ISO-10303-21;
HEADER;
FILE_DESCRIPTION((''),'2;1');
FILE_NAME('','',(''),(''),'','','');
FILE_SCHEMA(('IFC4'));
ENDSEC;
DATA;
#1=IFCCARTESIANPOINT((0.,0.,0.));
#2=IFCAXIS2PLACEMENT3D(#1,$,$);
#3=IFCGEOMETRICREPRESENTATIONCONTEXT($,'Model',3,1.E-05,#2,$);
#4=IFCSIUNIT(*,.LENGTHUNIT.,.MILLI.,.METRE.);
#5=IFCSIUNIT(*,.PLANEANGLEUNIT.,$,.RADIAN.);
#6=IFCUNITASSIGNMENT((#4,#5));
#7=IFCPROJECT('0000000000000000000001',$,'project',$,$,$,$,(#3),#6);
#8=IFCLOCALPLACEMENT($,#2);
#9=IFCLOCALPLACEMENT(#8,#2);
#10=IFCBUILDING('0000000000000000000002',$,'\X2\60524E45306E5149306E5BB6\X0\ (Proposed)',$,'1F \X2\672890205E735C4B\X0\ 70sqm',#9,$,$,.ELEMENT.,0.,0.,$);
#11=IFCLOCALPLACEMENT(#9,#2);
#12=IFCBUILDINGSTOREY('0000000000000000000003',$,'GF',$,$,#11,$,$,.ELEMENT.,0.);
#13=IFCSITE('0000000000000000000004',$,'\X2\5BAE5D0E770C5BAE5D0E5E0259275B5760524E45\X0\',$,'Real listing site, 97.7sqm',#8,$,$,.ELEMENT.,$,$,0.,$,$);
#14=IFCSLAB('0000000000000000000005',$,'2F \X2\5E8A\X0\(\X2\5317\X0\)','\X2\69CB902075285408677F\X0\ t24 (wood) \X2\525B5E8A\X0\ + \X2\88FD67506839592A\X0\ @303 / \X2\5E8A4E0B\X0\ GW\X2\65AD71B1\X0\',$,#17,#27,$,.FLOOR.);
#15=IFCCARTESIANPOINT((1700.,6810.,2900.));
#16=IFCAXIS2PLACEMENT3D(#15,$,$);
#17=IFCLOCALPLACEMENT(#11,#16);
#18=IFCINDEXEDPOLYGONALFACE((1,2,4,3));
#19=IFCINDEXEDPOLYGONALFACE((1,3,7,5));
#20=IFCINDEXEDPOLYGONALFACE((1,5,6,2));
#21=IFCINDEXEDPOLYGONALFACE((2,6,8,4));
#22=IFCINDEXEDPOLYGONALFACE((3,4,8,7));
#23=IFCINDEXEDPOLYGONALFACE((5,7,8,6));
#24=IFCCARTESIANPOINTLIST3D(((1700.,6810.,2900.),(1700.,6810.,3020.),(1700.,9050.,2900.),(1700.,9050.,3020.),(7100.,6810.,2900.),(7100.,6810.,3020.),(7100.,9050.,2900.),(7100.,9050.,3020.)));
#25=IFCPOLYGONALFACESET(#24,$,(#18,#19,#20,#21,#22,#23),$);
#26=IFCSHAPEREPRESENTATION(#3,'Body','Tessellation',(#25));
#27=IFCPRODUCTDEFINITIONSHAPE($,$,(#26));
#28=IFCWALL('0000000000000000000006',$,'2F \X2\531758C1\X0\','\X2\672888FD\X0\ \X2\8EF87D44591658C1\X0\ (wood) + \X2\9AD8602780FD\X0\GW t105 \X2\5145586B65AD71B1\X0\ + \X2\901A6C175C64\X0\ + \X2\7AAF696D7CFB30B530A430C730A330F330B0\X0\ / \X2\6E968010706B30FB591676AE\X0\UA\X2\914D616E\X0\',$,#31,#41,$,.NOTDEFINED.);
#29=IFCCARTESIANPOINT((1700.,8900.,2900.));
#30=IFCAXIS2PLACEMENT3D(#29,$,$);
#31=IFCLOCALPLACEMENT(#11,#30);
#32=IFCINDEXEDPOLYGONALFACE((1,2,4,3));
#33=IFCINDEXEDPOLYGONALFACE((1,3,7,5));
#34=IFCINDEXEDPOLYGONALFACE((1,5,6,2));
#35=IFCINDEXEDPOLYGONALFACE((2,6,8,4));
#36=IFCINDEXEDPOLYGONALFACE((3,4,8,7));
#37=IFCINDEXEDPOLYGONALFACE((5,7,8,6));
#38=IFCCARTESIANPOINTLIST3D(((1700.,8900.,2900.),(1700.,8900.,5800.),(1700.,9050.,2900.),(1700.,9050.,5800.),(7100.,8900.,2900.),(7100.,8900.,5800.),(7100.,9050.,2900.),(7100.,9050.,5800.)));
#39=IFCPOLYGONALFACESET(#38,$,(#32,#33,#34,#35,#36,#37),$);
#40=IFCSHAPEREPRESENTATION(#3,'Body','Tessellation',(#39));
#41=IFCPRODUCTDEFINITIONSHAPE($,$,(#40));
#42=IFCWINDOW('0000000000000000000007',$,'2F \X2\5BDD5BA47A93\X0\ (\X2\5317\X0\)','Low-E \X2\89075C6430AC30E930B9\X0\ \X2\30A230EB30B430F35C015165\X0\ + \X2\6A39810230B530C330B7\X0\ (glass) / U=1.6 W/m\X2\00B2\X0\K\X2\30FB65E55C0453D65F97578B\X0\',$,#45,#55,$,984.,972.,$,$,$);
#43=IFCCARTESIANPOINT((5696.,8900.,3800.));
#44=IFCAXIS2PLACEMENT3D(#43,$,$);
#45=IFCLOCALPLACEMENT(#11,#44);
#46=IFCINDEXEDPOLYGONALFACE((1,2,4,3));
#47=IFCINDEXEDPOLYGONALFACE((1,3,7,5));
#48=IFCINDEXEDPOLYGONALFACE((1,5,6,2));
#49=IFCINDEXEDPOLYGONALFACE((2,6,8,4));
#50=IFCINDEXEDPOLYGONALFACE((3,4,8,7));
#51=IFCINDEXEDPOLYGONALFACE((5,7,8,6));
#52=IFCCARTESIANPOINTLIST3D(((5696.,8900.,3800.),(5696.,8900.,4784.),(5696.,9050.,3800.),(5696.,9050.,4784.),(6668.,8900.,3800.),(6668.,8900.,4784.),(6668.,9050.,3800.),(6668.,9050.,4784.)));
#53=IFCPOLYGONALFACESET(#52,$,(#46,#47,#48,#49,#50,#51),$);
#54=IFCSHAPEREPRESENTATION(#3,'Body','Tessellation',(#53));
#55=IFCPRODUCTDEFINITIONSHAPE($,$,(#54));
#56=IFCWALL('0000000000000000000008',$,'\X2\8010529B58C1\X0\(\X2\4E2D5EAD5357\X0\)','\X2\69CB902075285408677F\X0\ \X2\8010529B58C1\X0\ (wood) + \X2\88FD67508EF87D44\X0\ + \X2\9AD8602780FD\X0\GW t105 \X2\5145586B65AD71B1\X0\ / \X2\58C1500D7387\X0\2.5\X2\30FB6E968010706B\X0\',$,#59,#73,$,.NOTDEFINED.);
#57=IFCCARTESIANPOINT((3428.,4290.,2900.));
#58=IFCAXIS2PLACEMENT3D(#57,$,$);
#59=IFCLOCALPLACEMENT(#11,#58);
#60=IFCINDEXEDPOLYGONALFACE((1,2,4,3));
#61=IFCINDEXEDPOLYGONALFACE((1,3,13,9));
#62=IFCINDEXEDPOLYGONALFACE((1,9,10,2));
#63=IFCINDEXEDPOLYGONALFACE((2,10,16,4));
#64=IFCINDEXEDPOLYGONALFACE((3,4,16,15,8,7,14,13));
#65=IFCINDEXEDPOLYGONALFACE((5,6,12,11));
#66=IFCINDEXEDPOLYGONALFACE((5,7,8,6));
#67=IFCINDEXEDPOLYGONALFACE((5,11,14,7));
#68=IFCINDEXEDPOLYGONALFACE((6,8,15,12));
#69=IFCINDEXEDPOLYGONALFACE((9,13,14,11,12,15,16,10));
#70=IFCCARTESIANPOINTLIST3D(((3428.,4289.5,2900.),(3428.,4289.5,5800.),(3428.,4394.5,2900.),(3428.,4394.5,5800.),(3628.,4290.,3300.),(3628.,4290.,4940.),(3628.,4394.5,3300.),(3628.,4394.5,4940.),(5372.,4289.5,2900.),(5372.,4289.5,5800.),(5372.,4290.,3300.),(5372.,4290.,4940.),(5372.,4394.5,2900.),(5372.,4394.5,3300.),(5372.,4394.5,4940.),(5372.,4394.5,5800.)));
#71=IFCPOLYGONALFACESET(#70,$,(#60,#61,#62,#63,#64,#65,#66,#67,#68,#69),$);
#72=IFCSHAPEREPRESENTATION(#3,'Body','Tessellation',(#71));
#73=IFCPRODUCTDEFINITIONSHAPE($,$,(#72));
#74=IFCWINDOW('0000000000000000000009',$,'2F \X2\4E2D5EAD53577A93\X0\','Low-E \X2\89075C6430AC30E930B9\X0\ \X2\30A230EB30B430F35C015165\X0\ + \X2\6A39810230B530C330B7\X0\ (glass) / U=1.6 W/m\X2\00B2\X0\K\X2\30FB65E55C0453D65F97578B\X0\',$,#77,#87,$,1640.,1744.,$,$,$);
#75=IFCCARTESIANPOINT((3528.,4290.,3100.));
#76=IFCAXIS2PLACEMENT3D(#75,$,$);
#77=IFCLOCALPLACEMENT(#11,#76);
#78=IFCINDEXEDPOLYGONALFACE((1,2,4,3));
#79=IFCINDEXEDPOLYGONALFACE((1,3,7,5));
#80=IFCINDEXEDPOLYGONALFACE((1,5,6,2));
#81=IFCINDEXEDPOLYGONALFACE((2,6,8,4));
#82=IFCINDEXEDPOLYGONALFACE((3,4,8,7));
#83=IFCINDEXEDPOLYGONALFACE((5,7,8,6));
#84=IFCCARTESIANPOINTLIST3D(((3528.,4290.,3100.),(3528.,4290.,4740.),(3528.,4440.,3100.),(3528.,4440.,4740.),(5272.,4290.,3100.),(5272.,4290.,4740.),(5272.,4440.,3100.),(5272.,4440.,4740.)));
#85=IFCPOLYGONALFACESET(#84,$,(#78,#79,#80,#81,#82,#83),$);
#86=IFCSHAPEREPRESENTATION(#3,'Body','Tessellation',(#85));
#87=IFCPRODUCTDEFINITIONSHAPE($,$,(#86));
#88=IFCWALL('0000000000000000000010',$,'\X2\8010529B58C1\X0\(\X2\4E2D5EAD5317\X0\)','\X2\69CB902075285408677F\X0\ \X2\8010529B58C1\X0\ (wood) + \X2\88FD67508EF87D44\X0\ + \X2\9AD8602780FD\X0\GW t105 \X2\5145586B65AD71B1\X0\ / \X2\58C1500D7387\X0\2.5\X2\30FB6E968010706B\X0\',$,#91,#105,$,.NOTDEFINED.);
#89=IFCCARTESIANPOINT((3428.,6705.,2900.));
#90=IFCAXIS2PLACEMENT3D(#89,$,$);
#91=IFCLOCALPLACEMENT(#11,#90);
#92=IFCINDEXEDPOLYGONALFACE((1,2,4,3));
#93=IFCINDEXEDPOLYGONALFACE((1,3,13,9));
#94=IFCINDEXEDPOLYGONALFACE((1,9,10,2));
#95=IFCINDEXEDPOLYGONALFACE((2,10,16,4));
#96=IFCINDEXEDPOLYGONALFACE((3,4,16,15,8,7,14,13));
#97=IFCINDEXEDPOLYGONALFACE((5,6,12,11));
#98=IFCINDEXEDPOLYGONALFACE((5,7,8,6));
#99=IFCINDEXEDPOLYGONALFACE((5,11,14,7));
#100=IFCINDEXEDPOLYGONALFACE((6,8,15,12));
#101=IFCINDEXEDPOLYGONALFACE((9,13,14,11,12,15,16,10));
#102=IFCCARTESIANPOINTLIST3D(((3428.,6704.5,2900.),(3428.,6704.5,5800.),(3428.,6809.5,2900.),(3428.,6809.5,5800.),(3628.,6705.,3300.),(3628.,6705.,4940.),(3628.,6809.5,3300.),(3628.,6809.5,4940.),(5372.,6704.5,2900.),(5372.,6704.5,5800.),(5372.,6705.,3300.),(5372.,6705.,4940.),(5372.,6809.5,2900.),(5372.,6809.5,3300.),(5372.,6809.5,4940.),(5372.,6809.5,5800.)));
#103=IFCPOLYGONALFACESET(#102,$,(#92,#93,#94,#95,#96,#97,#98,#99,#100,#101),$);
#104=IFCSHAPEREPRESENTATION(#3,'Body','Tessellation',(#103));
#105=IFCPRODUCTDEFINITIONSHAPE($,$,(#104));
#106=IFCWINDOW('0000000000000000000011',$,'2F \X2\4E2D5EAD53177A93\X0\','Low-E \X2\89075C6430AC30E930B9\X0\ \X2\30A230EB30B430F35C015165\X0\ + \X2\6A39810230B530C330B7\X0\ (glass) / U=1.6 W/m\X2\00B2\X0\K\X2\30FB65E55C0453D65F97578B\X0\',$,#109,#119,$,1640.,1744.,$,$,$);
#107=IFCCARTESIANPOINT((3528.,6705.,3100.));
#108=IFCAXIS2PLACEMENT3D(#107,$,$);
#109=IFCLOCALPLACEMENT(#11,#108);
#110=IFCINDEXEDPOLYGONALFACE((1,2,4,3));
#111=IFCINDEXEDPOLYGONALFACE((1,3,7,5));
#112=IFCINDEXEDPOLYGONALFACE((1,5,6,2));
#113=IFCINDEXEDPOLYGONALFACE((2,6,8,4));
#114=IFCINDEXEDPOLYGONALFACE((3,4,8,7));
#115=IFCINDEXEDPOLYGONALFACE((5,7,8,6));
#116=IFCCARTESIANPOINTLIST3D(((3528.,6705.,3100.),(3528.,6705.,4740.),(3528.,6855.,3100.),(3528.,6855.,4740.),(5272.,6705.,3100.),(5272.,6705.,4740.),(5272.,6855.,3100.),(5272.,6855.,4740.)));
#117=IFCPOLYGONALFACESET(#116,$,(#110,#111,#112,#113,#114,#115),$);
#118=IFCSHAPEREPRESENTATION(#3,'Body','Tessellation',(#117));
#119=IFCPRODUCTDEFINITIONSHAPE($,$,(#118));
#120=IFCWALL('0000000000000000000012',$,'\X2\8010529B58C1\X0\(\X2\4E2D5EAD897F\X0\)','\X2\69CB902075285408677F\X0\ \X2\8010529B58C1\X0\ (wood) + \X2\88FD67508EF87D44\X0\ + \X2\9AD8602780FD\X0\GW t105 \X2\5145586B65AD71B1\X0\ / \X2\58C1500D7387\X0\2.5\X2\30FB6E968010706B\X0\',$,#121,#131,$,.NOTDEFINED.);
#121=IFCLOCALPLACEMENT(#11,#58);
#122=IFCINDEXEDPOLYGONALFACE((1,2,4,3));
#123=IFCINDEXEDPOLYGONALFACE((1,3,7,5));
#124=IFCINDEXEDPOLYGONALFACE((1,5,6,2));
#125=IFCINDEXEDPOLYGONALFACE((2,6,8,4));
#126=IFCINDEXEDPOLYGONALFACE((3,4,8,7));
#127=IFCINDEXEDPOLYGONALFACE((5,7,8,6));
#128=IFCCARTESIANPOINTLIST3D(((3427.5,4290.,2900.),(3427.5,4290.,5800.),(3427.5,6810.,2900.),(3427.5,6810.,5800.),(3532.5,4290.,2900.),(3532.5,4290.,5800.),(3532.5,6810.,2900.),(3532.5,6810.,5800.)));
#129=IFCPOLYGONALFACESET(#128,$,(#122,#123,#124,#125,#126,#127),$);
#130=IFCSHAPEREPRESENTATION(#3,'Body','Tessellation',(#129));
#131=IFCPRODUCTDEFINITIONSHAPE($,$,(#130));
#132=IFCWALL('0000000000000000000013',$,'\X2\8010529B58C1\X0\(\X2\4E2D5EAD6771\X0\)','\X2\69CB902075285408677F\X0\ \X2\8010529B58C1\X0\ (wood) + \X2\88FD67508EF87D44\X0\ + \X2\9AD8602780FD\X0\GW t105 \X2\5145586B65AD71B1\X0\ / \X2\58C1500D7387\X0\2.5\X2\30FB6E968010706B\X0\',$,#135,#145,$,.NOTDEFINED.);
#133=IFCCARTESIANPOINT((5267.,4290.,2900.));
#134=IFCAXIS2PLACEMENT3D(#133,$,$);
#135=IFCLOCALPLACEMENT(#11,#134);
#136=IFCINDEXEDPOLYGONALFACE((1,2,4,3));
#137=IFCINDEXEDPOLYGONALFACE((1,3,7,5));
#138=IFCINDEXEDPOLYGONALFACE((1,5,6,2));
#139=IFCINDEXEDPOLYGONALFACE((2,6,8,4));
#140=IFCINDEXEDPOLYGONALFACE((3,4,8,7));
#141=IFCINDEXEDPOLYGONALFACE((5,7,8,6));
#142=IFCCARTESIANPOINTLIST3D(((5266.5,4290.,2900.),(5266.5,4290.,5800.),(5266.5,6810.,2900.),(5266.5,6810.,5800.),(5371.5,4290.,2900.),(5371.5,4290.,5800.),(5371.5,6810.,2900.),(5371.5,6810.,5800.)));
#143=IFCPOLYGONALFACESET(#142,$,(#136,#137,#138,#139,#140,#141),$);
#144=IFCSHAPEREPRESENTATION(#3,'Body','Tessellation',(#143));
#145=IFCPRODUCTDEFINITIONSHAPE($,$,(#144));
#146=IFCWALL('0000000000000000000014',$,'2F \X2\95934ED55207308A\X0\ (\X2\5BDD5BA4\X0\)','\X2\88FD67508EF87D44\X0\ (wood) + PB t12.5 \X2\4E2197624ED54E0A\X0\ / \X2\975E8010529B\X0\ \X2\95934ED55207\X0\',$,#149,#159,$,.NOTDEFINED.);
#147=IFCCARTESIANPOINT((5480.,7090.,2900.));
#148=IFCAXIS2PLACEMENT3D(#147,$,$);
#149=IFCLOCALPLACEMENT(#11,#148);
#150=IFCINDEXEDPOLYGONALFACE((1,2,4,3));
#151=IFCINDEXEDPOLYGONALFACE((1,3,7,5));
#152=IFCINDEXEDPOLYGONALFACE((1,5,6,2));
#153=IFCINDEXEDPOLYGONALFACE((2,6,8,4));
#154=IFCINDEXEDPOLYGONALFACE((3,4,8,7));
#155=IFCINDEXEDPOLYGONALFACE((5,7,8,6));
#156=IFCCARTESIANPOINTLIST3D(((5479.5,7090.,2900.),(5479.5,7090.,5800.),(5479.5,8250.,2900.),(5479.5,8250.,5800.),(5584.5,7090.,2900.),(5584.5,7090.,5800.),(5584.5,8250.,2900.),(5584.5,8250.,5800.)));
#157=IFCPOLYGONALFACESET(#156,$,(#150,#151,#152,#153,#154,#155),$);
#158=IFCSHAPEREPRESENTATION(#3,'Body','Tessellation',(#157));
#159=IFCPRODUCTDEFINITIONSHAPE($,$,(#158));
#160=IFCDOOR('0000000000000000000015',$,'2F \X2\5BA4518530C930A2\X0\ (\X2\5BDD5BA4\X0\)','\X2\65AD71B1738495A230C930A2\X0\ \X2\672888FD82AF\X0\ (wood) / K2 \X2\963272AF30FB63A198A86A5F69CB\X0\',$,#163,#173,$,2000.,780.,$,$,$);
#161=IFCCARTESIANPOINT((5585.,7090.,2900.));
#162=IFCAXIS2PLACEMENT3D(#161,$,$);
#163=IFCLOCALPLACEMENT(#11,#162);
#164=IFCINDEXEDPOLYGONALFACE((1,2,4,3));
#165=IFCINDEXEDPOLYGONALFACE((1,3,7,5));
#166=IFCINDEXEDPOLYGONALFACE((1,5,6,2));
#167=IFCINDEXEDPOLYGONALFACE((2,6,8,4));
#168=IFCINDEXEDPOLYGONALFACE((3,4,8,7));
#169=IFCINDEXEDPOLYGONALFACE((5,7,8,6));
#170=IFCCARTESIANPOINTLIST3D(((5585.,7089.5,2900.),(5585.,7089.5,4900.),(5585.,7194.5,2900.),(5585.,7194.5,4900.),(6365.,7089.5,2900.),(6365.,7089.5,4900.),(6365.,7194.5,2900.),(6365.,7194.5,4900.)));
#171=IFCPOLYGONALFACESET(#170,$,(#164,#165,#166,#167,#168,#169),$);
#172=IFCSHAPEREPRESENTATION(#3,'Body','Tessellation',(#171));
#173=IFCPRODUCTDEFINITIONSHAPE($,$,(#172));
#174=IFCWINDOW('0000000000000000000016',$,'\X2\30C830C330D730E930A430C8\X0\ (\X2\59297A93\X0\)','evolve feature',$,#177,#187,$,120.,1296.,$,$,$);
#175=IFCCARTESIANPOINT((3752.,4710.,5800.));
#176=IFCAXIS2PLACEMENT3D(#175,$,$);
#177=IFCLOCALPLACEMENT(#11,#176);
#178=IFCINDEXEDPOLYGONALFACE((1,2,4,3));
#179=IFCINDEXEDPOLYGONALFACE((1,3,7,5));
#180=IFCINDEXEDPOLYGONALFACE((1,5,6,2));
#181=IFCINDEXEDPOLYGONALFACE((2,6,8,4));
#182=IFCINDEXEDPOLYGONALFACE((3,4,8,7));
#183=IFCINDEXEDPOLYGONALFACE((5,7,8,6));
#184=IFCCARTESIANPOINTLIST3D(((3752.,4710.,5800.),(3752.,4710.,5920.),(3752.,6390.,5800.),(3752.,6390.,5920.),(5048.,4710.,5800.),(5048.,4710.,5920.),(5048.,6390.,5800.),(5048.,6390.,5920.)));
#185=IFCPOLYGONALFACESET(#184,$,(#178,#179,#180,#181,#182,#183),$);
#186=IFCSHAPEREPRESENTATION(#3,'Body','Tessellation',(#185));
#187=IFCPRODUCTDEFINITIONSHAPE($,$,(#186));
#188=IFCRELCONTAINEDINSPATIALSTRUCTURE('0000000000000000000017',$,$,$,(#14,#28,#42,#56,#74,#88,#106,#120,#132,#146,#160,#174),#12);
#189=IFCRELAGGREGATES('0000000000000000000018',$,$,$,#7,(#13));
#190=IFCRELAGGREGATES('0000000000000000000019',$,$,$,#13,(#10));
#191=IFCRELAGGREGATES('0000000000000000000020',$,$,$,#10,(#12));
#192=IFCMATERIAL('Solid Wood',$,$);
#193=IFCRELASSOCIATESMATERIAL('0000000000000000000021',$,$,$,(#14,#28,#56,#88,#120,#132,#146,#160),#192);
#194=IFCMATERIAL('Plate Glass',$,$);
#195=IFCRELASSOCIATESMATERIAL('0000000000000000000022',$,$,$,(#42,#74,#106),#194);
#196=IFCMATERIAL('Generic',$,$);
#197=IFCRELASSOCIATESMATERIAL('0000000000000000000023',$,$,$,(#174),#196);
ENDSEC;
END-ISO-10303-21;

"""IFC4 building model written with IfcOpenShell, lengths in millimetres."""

from ifc_helpers import new_model, si_unit, frame, frame_2d, origin, place, context, project, spatial, rectangle, extrude, material, element, fill, save


model = new_model("IFC4")

# Units and contexts
model_context = context("Model", 3, precision=1e-05, world=origin())
ifc_project = project(units=[si_unit("LENGTHUNIT", "METRE", prefix="MILLI"), si_unit("PLANEANGLEUNIT", "RADIAN")], contexts=[model_context])

# Site, building, storey
site_placement = place(None, origin())
site = spatial("IfcSite", under=ifc_project, at=site_placement, Name="宮崎県宮崎市大字恒久", ObjectType="Real listing site, 97.7sqm", CompositionType="ELEMENT", RefElevation=0.0)
building_placement = place(site_placement, origin())
building = spatial("IfcBuilding", under=site, at=building_placement, Name="恒久の光の家 (Proposed)", ObjectType="1F 木造平屋 70sqm", CompositionType="ELEMENT", ElevationOfRefHeight=0.0, ElevationOfTerrain=0.0)
storey_placement = place(building_placement, origin())
storey = spatial("IfcBuildingStorey", under=building, at=storey_placement, Name="GF", CompositionType="ELEMENT", Elevation=0.0)

# Slab
ifc_material_1 = material(Name="Solid Wood")
slab_placement = place(storey_placement, frame((1700.0, 6810.0, 2900.0)))
element("IfcSlab", 1, at=slab_placement, inside=storey, material=ifc_material_1, Name="2F 床(北)", Description="構造用合板 t24 (wood) 剛床 + 製材根太 @303 / 床下 GW断熱", PredefinedType="FLOOR", context=model_context, shape_type="SweptSolid", body=[
    extrude(rectangle(XDim=5400.0, YDim=2240.0, at=frame_2d((2700.0, 1120.0))), frame((1700.0, 6810.0, 2900.0)), (0.0, 0.0, 1.0), 120.0),
])

# Walls, openings, windows
wall_1_placement = place(storey_placement, frame((1700.0, 8900.0, 2900.0)))
wall_1 = element("IfcWall", 2, at=wall_1_placement, inside=storey, material=ifc_material_1, Name="2F 北壁", Description="木製 軸組外壁 (wood) + 高性能GW t105 充填断熱 + 通気層 + 窯業系サイディング / 準耐火・外皮UA配慮", PredefinedType="NOTDEFINED", context=model_context, shape_type="SweptSolid", body=[
    extrude(rectangle(XDim=5400.0, YDim=150.0, at=frame_2d((2700.0, 75.0))), frame((1700.0, 8900.0, 2900.0)), (0.0, 0.0, 1.0), 2900.0),
])
opening_1_placement = place(storey_placement, frame((5696.0, 8900.0, 3800.0)))
opening_1 = element("IfcOpeningElement", 3, at=opening_1_placement, cuts=wall_1, PredefinedType="NOTDEFINED", context=model_context, shape_type="SweptSolid", body=[
    extrude(rectangle(XDim=972.0, YDim=150.0, at=frame_2d((486.0, 75.0))), frame((5696.0, 8900.0, 3800.0)), (0.0, 0.0, 1.0), 984.0),
])
ifc_material_2 = material(Name="Plate Glass")
window_1_placement = place(storey_placement, frame((5696.0, 8900.0, 3800.0)))
window_1 = element("IfcWindow", 4, at=window_1_placement, inside=storey, material=ifc_material_2, Name="2F 寝室窓 (北)", Description="Low-E 複層ガラス アルゴン封入 + 樹脂サッシ (glass) / U=1.6 W/m²K・日射取得型", OverallHeight=984.0, OverallWidth=972.0, context=model_context, shape_type="SweptSolid", body=[
    extrude(rectangle(XDim=972.0, YDim=150.0, at=frame_2d((486.0, 75.0))), frame((5696.0, 8900.0, 3800.0)), (0.0, 0.0, 1.0), 984.0),
])
fill(opening_1, window_1)
wall_2_placement = place(storey_placement, frame((3428.0, 4290.0, 2900.0)))
wall_2 = element("IfcWall", 5, at=wall_2_placement, inside=storey, material=ifc_material_1, Name="耐力壁(中庭南)", Description="構造用合板 耐力壁 (wood) + 製材軸組 + 高性能GW t105 充填断熱 / 壁倍率2.5・準耐火", PredefinedType="NOTDEFINED", context=model_context, shape_type="SweptSolid", body=[
    extrude(rectangle(XDim=1944.0, YDim=105.0, at=frame_2d((972.0, 52.0))), frame((3428.0, 4290.0, 2900.0)), (0.0, 0.0, 1.0), 2900.0),
])
opening_2_placement = place(storey_placement, frame((3528.0, 4290.0, 3100.0)))
opening_2 = element("IfcOpeningElement", 6, at=opening_2_placement, cuts=wall_2, PredefinedType="NOTDEFINED", context=model_context, shape_type="SweptSolid", body=[
    extrude(rectangle(XDim=1744.0, YDim=150.0, at=frame_2d((872.0, 75.0))), frame((3528.0, 4290.0, 3100.0)), (0.0, 0.0, 1.0), 1640.0),
])
window_2_placement = place(storey_placement, frame((3528.0, 4290.0, 3100.0)))
window_2 = element("IfcWindow", 7, at=window_2_placement, inside=storey, material=ifc_material_2, Name="2F 中庭南窓", Description="Low-E 複層ガラス アルゴン封入 + 樹脂サッシ (glass) / U=1.6 W/m²K・日射取得型", OverallHeight=1640.0, OverallWidth=1744.0, context=model_context, shape_type="SweptSolid", body=[
    extrude(rectangle(XDim=1744.0, YDim=150.0, at=frame_2d((872.0, 75.0))), frame((3528.0, 4290.0, 3100.0)), (0.0, 0.0, 1.0), 1640.0),
])
fill(opening_2, window_2)
wall_3_placement = place(storey_placement, frame((3428.0, 6705.0, 2900.0)))
wall_3 = element("IfcWall", 8, at=wall_3_placement, inside=storey, material=ifc_material_1, Name="耐力壁(中庭北)", Description="構造用合板 耐力壁 (wood) + 製材軸組 + 高性能GW t105 充填断熱 / 壁倍率2.5・準耐火", PredefinedType="NOTDEFINED", context=model_context, shape_type="SweptSolid", body=[
    extrude(rectangle(XDim=1944.0, YDim=105.0, at=frame_2d((972.0, 52.0))), frame((3428.0, 6705.0, 2900.0)), (0.0, 0.0, 1.0), 2900.0),
])
opening_3_placement = place(storey_placement, frame((3528.0, 6705.0, 3100.0)))
opening_3 = element("IfcOpeningElement", 9, at=opening_3_placement, cuts=wall_3, PredefinedType="NOTDEFINED", context=model_context, shape_type="SweptSolid", body=[
    extrude(rectangle(XDim=1744.0, YDim=150.0, at=frame_2d((872.0, 75.0))), frame((3528.0, 6705.0, 3100.0)), (0.0, 0.0, 1.0), 1640.0),
])
window_3_placement = place(storey_placement, frame((3528.0, 6705.0, 3100.0)))
window_3 = element("IfcWindow", 10, at=window_3_placement, inside=storey, material=ifc_material_2, Name="2F 中庭北窓", Description="Low-E 複層ガラス アルゴン封入 + 樹脂サッシ (glass) / U=1.6 W/m²K・日射取得型", OverallHeight=1640.0, OverallWidth=1744.0, context=model_context, shape_type="SweptSolid", body=[
    extrude(rectangle(XDim=1744.0, YDim=150.0, at=frame_2d((872.0, 75.0))), frame((3528.0, 6705.0, 3100.0)), (0.0, 0.0, 1.0), 1640.0),
])
fill(opening_3, window_3)

# Walls
wall_4_placement = place(storey_placement, frame((3428.0, 4290.0, 2900.0)))
element("IfcWall", 11, at=wall_4_placement, inside=storey, material=ifc_material_1, Name="耐力壁(中庭西)", Description="構造用合板 耐力壁 (wood) + 製材軸組 + 高性能GW t105 充填断熱 / 壁倍率2.5・準耐火", PredefinedType="NOTDEFINED", context=model_context, shape_type="SweptSolid", body=[
    extrude(rectangle(XDim=105.0, YDim=2520.0, at=frame_2d((52.0, 1260.0))), frame((3428.0, 4290.0, 2900.0)), (0.0, 0.0, 1.0), 2900.0),
])
wall_5_placement = place(storey_placement, frame((5267.0, 4290.0, 2900.0)))
element("IfcWall", 12, at=wall_5_placement, inside=storey, material=ifc_material_1, Name="耐力壁(中庭東)", Description="構造用合板 耐力壁 (wood) + 製材軸組 + 高性能GW t105 充填断熱 / 壁倍率2.5・準耐火", PredefinedType="NOTDEFINED", context=model_context, shape_type="SweptSolid", body=[
    extrude(rectangle(XDim=105.0, YDim=2520.0, at=frame_2d((52.0, 1260.0))), frame((5267.0, 4290.0, 2900.0)), (0.0, 0.0, 1.0), 2900.0),
])
wall_6_placement = place(storey_placement, frame((5480.0, 7090.0, 2900.0)))
element("IfcWall", 13, at=wall_6_placement, inside=storey, material=ifc_material_1, Name="2F 間仕切り (寝室)", Description="製材軸組 (wood) + PB t12.5 両面仕上 / 非耐力 間仕切", PredefinedType="NOTDEFINED", context=model_context, shape_type="SweptSolid", body=[
    extrude(rectangle(XDim=105.0, YDim=1160.0, at=frame_2d((52.0, 580.0))), frame((5480.0, 7090.0, 2900.0)), (0.0, 0.0, 1.0), 2900.0),
])

# Door
door_placement = place(storey_placement, frame((5585.0, 7090.0, 2900.0)))
element("IfcDoor", 14, at=door_placement, inside=storey, material=ifc_material_1, Name="2F 室内ドア (寝室)", Description="断熱玄関ドア 木製芯 (wood) / K2 防犯・採風機構", OverallHeight=2000.0, OverallWidth=780.0, context=model_context, shape_type="SweptSolid", body=[
    extrude(rectangle(XDim=780.0, YDim=105.0, at=frame_2d((390.0, 52.0))), frame((5585.0, 7090.0, 2900.0)), (0.0, 0.0, 1.0), 2000.0),
])

# Window
ifc_material_3 = material(Name="Generic")
window_4_placement = place(storey_placement, frame((3752.0, 4710.0, 5800.0)))
element("IfcWindow", 15, at=window_4_placement, inside=storey, material=ifc_material_3, Name="トップライト (天窓)", Description="evolve feature", OverallHeight=120.0, OverallWidth=1296.0, context=model_context, shape_type="SweptSolid", body=[
    extrude(rectangle(XDim=1296.0, YDim=1680.0, at=frame_2d((648.0, 840.0))), frame((3752.0, 4710.0, 5800.0)), (0.0, 0.0, 1.0), 120.0),
])

save(model, "model.ifc")
